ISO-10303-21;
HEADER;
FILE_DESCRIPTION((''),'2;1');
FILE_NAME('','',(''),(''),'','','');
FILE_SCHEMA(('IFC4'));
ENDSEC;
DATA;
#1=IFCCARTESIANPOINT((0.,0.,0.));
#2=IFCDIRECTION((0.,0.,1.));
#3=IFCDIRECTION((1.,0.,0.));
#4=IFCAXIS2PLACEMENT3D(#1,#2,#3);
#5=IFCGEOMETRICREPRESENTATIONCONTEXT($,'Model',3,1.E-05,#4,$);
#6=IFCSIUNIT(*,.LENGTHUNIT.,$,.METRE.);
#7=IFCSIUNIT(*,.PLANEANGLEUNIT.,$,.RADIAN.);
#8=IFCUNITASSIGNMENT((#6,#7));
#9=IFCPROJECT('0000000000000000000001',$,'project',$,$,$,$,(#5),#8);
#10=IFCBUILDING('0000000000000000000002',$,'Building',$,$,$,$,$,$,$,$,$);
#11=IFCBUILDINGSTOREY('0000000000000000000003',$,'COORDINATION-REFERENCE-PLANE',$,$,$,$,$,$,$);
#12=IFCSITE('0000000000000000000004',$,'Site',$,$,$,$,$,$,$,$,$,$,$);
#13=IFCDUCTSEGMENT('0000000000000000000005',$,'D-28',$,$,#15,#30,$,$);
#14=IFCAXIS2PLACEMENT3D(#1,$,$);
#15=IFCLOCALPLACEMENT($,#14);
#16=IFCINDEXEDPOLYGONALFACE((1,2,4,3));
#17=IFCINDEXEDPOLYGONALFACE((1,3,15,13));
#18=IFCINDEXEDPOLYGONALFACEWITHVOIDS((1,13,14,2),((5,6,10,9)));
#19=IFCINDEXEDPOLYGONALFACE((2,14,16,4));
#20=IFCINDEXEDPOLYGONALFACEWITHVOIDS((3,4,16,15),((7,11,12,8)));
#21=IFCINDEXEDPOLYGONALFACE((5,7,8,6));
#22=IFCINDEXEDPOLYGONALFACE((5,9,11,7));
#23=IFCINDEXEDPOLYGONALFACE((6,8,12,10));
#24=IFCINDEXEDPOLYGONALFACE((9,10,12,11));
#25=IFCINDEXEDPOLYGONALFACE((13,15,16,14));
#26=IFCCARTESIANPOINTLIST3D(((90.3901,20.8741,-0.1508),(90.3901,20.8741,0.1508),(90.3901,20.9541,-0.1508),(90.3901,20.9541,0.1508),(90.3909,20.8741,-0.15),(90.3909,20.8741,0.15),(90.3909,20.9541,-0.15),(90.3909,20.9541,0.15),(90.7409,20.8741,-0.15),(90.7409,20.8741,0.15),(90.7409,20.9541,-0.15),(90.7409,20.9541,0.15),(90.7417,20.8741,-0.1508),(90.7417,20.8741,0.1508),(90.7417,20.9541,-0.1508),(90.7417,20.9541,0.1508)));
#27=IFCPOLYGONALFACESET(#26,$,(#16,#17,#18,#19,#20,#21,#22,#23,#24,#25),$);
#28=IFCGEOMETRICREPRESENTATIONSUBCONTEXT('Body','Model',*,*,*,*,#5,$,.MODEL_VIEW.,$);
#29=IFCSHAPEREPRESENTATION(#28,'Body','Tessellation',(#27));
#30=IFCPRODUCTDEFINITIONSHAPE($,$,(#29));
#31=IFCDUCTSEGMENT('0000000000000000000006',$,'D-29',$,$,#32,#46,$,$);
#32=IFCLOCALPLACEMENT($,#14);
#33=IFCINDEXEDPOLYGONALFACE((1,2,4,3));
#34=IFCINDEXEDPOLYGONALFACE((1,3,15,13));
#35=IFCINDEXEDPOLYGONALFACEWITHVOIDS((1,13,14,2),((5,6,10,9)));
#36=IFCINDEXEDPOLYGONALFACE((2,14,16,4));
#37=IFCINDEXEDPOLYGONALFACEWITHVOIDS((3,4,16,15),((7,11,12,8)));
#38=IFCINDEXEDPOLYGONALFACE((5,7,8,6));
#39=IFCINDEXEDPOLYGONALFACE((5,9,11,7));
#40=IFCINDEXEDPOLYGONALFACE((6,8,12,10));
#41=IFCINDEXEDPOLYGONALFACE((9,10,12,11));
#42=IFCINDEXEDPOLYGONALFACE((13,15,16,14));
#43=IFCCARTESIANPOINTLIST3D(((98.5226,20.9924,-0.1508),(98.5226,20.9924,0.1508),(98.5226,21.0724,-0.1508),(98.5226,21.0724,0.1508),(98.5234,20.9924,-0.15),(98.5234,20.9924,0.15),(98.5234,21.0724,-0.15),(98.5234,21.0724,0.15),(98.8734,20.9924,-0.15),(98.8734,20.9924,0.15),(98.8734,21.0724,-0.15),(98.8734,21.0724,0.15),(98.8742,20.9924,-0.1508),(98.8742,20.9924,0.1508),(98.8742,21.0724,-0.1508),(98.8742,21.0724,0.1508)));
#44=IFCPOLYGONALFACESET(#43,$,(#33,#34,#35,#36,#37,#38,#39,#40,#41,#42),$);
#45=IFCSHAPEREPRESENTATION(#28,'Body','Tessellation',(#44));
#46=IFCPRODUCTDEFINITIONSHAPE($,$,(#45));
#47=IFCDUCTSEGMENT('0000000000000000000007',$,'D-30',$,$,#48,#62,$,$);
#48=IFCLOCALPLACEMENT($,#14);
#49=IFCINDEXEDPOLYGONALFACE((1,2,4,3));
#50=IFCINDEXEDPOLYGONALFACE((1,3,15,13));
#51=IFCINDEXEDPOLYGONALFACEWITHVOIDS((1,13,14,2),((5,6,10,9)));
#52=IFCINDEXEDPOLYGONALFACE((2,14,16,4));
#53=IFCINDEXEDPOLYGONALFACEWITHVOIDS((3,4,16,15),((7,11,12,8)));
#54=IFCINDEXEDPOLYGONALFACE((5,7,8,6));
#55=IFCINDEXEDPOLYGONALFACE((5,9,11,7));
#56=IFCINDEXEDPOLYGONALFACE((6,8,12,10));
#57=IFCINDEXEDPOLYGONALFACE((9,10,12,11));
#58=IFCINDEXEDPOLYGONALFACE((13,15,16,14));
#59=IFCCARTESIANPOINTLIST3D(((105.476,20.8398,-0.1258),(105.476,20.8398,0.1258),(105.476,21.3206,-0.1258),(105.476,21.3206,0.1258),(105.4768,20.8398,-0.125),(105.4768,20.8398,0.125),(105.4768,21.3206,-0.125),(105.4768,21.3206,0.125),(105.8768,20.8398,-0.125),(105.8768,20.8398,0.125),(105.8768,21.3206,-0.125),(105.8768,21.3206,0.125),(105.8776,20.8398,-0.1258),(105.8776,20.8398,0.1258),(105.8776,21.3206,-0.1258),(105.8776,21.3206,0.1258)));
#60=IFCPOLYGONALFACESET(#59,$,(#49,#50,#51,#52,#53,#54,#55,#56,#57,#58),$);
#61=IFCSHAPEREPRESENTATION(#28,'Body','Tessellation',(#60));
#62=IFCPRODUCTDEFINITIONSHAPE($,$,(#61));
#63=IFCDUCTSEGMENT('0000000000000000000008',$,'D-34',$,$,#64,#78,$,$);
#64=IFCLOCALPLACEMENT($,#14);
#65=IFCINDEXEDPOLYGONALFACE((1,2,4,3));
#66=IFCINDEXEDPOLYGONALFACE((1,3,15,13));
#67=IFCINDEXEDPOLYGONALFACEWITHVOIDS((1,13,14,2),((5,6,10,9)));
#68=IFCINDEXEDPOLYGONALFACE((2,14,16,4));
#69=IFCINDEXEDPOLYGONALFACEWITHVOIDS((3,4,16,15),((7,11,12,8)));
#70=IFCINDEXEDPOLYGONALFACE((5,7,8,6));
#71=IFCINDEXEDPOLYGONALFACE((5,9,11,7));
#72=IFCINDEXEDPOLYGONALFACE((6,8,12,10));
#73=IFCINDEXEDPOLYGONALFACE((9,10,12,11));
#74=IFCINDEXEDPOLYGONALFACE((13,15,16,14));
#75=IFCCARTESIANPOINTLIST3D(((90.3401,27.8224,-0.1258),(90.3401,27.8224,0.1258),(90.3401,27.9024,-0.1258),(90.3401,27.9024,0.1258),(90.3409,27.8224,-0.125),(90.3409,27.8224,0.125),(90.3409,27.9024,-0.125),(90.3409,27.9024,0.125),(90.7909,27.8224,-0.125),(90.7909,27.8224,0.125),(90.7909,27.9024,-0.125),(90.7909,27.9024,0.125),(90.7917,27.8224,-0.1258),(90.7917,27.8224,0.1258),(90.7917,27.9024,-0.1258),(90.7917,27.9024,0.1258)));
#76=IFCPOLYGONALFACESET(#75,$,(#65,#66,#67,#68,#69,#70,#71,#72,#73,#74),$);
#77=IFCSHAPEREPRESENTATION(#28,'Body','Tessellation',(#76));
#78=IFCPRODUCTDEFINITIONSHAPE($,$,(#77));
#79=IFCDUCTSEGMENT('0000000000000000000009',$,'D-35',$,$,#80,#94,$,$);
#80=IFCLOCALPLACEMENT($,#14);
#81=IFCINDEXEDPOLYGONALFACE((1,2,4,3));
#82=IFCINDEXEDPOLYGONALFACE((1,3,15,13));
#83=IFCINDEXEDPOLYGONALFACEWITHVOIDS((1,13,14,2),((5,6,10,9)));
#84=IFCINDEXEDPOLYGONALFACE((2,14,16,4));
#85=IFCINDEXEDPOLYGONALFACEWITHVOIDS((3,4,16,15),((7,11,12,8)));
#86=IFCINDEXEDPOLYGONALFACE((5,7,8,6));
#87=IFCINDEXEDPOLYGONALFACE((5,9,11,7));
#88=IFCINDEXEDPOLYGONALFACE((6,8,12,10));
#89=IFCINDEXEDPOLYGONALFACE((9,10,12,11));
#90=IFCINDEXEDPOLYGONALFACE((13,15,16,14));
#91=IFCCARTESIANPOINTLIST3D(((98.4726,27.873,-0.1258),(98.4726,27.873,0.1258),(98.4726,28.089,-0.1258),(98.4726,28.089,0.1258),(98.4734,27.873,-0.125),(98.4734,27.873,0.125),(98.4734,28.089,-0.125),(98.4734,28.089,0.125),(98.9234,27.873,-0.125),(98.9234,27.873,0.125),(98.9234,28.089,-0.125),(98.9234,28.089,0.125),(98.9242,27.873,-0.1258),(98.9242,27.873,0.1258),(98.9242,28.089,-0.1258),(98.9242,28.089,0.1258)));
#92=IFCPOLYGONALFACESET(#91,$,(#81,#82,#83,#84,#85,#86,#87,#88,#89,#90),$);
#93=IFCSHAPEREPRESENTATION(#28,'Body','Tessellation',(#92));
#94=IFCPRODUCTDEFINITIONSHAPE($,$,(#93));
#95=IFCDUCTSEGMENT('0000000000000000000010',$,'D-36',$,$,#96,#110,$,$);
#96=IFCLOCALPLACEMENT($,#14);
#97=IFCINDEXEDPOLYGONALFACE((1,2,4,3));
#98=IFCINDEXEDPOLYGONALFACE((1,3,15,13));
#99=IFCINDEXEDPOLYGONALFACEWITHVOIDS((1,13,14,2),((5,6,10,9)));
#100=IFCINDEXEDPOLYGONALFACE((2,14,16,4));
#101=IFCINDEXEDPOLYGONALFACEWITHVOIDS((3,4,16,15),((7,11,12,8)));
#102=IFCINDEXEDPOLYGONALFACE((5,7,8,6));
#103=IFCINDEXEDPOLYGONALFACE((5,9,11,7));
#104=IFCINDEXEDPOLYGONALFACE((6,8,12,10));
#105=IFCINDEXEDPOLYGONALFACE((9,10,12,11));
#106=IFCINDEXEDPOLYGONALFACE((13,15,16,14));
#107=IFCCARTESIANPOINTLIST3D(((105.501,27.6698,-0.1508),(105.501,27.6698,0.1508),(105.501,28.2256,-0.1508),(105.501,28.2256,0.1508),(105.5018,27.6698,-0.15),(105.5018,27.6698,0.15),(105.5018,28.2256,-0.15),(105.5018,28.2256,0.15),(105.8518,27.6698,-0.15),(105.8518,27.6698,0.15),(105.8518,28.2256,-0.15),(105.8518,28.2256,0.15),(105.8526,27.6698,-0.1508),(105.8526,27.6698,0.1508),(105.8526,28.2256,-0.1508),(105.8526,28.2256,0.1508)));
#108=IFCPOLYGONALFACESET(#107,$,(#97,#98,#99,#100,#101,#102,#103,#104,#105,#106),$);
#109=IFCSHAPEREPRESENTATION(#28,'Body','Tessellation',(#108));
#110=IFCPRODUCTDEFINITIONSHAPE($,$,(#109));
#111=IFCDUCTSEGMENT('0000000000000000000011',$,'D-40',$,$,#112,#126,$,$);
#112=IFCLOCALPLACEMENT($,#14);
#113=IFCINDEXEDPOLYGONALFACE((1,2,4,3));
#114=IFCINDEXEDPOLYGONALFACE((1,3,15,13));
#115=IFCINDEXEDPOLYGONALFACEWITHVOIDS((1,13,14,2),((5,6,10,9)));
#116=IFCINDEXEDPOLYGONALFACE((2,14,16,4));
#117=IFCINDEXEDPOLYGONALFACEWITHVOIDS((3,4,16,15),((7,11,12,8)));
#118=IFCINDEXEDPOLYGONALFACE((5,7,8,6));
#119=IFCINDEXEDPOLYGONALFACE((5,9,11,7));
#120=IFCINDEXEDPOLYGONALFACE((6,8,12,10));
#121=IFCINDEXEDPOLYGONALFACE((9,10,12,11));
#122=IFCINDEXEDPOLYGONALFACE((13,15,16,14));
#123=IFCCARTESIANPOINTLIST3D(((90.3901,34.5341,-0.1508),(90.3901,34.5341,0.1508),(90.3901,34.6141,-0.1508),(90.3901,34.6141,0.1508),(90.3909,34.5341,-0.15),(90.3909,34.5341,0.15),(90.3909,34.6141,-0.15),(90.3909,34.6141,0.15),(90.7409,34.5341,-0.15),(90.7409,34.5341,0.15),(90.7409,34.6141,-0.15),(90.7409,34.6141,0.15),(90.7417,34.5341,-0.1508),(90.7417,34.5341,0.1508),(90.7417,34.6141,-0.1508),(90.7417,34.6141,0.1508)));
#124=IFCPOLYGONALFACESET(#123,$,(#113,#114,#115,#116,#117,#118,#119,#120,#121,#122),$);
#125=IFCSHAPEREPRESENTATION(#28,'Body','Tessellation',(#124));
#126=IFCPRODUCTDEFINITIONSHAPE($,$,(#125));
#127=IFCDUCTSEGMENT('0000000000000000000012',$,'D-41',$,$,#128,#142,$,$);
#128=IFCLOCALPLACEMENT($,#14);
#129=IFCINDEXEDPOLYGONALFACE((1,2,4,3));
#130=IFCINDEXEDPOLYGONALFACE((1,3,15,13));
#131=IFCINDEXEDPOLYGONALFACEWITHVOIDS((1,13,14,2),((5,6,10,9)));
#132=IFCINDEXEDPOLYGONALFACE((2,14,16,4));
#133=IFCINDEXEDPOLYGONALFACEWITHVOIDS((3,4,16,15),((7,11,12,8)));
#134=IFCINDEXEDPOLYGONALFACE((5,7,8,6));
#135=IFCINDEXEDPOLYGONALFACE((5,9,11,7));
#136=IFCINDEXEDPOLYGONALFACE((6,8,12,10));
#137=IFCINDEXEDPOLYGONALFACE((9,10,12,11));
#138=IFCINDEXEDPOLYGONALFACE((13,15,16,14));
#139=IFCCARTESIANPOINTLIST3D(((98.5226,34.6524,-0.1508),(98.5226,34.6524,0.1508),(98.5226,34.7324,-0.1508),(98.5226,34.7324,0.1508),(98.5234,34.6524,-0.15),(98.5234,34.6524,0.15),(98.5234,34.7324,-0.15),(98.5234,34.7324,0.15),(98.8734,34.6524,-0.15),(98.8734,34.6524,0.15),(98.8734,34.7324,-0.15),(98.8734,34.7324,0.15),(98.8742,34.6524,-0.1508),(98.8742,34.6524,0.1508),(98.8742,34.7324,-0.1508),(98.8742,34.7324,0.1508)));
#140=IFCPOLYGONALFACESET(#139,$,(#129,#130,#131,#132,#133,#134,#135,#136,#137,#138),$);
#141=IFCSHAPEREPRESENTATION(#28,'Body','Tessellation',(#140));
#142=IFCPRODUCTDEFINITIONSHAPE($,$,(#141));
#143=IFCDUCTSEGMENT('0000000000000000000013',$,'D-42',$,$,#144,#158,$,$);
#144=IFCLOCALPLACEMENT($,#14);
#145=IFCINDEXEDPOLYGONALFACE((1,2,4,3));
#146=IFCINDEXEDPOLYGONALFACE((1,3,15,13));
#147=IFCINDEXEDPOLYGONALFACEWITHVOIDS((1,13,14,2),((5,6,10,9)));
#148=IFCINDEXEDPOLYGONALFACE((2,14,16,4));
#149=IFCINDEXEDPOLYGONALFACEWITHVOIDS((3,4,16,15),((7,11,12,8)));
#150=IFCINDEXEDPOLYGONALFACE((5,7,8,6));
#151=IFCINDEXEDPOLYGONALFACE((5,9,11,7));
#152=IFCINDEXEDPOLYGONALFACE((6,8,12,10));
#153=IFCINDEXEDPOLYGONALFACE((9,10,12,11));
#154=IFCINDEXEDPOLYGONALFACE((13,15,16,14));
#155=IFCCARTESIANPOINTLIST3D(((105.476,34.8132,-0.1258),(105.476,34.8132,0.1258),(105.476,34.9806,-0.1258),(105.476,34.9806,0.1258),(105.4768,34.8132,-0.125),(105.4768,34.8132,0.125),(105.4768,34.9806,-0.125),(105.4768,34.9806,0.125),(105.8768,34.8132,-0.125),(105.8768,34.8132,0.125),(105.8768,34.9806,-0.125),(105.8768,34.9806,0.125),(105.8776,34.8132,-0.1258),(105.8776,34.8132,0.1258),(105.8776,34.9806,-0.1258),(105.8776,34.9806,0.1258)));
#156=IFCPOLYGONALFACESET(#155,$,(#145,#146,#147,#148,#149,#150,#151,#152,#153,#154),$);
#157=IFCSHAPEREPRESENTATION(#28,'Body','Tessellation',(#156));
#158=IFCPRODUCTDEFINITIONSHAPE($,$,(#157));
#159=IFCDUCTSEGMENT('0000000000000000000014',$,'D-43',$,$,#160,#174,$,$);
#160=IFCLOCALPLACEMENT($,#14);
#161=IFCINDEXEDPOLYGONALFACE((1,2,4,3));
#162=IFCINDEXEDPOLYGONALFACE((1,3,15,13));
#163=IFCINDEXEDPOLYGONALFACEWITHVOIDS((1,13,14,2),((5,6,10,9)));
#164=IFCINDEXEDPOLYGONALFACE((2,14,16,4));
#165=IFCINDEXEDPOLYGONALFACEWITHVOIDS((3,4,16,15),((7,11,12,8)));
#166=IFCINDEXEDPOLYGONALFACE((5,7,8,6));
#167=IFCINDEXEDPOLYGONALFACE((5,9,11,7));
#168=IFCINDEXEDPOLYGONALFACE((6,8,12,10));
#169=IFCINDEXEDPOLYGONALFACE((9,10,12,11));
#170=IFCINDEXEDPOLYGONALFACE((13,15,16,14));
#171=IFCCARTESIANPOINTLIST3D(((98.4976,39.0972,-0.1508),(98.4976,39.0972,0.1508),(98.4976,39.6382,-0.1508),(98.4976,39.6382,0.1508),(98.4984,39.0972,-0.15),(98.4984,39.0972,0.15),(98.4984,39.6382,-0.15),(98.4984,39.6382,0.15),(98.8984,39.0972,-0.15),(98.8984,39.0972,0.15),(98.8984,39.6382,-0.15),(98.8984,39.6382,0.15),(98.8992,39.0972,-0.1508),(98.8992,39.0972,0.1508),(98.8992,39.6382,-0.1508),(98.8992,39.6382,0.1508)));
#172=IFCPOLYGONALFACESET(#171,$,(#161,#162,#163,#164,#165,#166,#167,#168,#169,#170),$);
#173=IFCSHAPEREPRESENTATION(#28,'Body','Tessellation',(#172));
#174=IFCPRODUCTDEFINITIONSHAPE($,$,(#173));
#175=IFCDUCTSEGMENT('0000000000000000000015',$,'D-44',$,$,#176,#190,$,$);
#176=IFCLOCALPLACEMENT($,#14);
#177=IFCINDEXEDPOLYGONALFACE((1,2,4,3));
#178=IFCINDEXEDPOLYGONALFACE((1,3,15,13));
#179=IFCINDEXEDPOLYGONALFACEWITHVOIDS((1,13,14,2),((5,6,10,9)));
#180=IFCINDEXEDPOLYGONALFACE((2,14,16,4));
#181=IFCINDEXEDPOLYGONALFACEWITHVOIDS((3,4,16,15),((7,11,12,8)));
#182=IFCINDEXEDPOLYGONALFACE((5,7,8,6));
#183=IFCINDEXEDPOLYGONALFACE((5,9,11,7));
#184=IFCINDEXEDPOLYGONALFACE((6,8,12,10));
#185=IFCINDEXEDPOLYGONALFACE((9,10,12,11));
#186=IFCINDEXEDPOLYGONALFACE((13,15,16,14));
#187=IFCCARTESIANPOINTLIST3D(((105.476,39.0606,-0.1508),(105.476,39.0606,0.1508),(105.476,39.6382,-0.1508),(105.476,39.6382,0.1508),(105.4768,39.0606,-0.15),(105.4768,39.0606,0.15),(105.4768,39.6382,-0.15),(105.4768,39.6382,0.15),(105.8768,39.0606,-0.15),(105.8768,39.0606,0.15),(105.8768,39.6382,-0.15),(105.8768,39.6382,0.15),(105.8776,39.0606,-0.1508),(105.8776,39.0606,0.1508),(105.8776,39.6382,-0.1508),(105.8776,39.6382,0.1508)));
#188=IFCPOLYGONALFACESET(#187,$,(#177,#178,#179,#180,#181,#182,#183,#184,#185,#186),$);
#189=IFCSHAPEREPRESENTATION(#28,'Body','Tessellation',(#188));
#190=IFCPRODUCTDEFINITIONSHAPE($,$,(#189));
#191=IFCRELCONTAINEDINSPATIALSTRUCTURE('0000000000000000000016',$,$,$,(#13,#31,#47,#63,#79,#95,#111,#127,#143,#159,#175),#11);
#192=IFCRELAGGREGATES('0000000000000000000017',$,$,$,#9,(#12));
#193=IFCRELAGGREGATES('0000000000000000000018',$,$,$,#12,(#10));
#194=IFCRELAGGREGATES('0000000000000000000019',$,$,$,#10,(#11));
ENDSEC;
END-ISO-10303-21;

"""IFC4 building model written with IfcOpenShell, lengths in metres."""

from ifc_helpers import new_model, si_unit, frame, origin, origin_with_axes, place, context, subcontext, project, spatial, hollow_rectangle, extrude, element, save


model = new_model("IFC4")

# Units and contexts
model_context = context("Model", 3, precision=1e-05, world=origin_with_axes())
body_context = subcontext(model_context, "Body", "Model", "MODEL_VIEW")
ifc_project = project(units=[si_unit("LENGTHUNIT", "METRE"), si_unit("PLANEANGLEUNIT", "RADIAN")], contexts=[model_context])

# Site, building, storey
site = spatial("IfcSite", under=ifc_project, Name="Site")
building = spatial("IfcBuilding", under=site, Name="Building")
storey = spatial("IfcBuildingStorey", under=building, Name="COORDINATION-REFERENCE-PLANE")

# Duct segments
for number, where, z_axis, x_axis, name in (
    (1, (90.5659, 20.8741, 0.0), (0.0, 1.0, 0.0), (1.0, 0.0, 0.0), "D-28"),
    (2, (98.6984, 20.9924, 0.0), (0.0, 1.0, 0.0), (1.0, 0.0, 0.0), "D-29"),
):
    element("IfcDuctSegment", number, at=place(None, frame(where, z_axis=z_axis, x_axis=x_axis)), inside=storey, Name=name, context=body_context, shape_type="SweptSolid", body=[
        extrude(hollow_rectangle(XDim=0.3516, YDim=0.3016, WallThickness=0.0008), origin(), (0.0, 0.0, 1.0), 0.08),
    ])
duct_segment_1_placement = place(None, frame((105.6768, 20.8398, 0.0), z_axis=(0.0, 1.0, 0.0), x_axis=(1.0, 0.0, 0.0)))
element("IfcDuctSegment", 3, at=duct_segment_1_placement, inside=storey, Name="D-30", context=body_context, shape_type="SweptSolid", body=[
    extrude(hollow_rectangle(XDim=0.4016, YDim=0.2516, WallThickness=0.0008), origin(), (0.0, 0.0, 1.0), 0.4808),
])
duct_segment_2_placement = place(None, frame((90.5659, 27.8224, 0.0), z_axis=(0.0, 1.0, 0.0), x_axis=(1.0, 0.0, 0.0)))
element("IfcDuctSegment", 4, at=duct_segment_2_placement, inside=storey, Name="D-34", context=body_context, shape_type="SweptSolid", body=[
    extrude(hollow_rectangle(XDim=0.4516, YDim=0.2516, WallThickness=0.0008), origin(), (0.0, 0.0, 1.0), 0.08),
])
duct_segment_3_placement = place(None, frame((98.6984, 27.873, 0.0), z_axis=(0.0, 1.0, 0.0), x_axis=(1.0, 0.0, 0.0)))
element("IfcDuctSegment", 5, at=duct_segment_3_placement, inside=storey, Name="D-35", context=body_context, shape_type="SweptSolid", body=[
    extrude(hollow_rectangle(XDim=0.4516, YDim=0.2516, WallThickness=0.0008), origin(), (0.0, 0.0, 1.0), 0.216),
])
duct_segment_4_placement = place(None, frame((105.6768, 27.6698, 0.0), z_axis=(0.0, 1.0, 0.0), x_axis=(1.0, 0.0, 0.0)))
element("IfcDuctSegment", 6, at=duct_segment_4_placement, inside=storey, Name="D-36", context=body_context, shape_type="SweptSolid", body=[
    extrude(hollow_rectangle(XDim=0.3516, YDim=0.3016, WallThickness=0.0008), origin(), (0.0, 0.0, 1.0), 0.5558),
])
for number, where, z_axis, x_axis, name in (
    (7, (90.5659, 34.5341, 0.0), (0.0, 1.0, 0.0), (1.0, 0.0, 0.0), "D-40"),
    (8, (98.6984, 34.6524, 0.0), (0.0, 1.0, 0.0), (1.0, 0.0, 0.0), "D-41"),
):
    element("IfcDuctSegment", number, at=place(None, frame(where, z_axis=z_axis, x_axis=x_axis)), inside=storey, Name=name, context=body_context, shape_type="SweptSolid", body=[
        extrude(hollow_rectangle(XDim=0.3516, YDim=0.3016, WallThickness=0.0008), origin(), (0.0, 0.0, 1.0), 0.08),
    ])
duct_segment_5_placement = place(None, frame((105.6768, 34.8132, 0.0), z_axis=(0.0, 1.0, 0.0), x_axis=(1.0, 0.0, 0.0)))
element("IfcDuctSegment", 9, at=duct_segment_5_placement, inside=storey, Name="D-42", context=body_context, shape_type="SweptSolid", body=[
    extrude(hollow_rectangle(XDim=0.4016, YDim=0.2516, WallThickness=0.0008), origin(), (0.0, 0.0, 1.0), 0.1673),
])
duct_segment_6_placement = place(None, frame((98.6984, 39.0972, 0.0), z_axis=(0.0, 1.0, 0.0), x_axis=(1.0, 0.0, 0.0)))
element("IfcDuctSegment", 10, at=duct_segment_6_placement, inside=storey, Name="D-43", context=body_context, shape_type="SweptSolid", body=[
    extrude(hollow_rectangle(XDim=0.4016, YDim=0.3016, WallThickness=0.0008), origin(), (0.0, 0.0, 1.0), 0.541),
])
duct_segment_7_placement = place(None, frame((105.6768, 39.0606, 0.0), z_axis=(0.0, 1.0, 0.0), x_axis=(1.0, 0.0, 0.0)))
element("IfcDuctSegment", 11, at=duct_segment_7_placement, inside=storey, Name="D-44", context=body_context, shape_type="SweptSolid", body=[
    extrude(hollow_rectangle(XDim=0.4016, YDim=0.3016, WallThickness=0.0008), origin(), (0.0, 0.0, 1.0), 0.5776),
])

save(model, "model.ifc")
